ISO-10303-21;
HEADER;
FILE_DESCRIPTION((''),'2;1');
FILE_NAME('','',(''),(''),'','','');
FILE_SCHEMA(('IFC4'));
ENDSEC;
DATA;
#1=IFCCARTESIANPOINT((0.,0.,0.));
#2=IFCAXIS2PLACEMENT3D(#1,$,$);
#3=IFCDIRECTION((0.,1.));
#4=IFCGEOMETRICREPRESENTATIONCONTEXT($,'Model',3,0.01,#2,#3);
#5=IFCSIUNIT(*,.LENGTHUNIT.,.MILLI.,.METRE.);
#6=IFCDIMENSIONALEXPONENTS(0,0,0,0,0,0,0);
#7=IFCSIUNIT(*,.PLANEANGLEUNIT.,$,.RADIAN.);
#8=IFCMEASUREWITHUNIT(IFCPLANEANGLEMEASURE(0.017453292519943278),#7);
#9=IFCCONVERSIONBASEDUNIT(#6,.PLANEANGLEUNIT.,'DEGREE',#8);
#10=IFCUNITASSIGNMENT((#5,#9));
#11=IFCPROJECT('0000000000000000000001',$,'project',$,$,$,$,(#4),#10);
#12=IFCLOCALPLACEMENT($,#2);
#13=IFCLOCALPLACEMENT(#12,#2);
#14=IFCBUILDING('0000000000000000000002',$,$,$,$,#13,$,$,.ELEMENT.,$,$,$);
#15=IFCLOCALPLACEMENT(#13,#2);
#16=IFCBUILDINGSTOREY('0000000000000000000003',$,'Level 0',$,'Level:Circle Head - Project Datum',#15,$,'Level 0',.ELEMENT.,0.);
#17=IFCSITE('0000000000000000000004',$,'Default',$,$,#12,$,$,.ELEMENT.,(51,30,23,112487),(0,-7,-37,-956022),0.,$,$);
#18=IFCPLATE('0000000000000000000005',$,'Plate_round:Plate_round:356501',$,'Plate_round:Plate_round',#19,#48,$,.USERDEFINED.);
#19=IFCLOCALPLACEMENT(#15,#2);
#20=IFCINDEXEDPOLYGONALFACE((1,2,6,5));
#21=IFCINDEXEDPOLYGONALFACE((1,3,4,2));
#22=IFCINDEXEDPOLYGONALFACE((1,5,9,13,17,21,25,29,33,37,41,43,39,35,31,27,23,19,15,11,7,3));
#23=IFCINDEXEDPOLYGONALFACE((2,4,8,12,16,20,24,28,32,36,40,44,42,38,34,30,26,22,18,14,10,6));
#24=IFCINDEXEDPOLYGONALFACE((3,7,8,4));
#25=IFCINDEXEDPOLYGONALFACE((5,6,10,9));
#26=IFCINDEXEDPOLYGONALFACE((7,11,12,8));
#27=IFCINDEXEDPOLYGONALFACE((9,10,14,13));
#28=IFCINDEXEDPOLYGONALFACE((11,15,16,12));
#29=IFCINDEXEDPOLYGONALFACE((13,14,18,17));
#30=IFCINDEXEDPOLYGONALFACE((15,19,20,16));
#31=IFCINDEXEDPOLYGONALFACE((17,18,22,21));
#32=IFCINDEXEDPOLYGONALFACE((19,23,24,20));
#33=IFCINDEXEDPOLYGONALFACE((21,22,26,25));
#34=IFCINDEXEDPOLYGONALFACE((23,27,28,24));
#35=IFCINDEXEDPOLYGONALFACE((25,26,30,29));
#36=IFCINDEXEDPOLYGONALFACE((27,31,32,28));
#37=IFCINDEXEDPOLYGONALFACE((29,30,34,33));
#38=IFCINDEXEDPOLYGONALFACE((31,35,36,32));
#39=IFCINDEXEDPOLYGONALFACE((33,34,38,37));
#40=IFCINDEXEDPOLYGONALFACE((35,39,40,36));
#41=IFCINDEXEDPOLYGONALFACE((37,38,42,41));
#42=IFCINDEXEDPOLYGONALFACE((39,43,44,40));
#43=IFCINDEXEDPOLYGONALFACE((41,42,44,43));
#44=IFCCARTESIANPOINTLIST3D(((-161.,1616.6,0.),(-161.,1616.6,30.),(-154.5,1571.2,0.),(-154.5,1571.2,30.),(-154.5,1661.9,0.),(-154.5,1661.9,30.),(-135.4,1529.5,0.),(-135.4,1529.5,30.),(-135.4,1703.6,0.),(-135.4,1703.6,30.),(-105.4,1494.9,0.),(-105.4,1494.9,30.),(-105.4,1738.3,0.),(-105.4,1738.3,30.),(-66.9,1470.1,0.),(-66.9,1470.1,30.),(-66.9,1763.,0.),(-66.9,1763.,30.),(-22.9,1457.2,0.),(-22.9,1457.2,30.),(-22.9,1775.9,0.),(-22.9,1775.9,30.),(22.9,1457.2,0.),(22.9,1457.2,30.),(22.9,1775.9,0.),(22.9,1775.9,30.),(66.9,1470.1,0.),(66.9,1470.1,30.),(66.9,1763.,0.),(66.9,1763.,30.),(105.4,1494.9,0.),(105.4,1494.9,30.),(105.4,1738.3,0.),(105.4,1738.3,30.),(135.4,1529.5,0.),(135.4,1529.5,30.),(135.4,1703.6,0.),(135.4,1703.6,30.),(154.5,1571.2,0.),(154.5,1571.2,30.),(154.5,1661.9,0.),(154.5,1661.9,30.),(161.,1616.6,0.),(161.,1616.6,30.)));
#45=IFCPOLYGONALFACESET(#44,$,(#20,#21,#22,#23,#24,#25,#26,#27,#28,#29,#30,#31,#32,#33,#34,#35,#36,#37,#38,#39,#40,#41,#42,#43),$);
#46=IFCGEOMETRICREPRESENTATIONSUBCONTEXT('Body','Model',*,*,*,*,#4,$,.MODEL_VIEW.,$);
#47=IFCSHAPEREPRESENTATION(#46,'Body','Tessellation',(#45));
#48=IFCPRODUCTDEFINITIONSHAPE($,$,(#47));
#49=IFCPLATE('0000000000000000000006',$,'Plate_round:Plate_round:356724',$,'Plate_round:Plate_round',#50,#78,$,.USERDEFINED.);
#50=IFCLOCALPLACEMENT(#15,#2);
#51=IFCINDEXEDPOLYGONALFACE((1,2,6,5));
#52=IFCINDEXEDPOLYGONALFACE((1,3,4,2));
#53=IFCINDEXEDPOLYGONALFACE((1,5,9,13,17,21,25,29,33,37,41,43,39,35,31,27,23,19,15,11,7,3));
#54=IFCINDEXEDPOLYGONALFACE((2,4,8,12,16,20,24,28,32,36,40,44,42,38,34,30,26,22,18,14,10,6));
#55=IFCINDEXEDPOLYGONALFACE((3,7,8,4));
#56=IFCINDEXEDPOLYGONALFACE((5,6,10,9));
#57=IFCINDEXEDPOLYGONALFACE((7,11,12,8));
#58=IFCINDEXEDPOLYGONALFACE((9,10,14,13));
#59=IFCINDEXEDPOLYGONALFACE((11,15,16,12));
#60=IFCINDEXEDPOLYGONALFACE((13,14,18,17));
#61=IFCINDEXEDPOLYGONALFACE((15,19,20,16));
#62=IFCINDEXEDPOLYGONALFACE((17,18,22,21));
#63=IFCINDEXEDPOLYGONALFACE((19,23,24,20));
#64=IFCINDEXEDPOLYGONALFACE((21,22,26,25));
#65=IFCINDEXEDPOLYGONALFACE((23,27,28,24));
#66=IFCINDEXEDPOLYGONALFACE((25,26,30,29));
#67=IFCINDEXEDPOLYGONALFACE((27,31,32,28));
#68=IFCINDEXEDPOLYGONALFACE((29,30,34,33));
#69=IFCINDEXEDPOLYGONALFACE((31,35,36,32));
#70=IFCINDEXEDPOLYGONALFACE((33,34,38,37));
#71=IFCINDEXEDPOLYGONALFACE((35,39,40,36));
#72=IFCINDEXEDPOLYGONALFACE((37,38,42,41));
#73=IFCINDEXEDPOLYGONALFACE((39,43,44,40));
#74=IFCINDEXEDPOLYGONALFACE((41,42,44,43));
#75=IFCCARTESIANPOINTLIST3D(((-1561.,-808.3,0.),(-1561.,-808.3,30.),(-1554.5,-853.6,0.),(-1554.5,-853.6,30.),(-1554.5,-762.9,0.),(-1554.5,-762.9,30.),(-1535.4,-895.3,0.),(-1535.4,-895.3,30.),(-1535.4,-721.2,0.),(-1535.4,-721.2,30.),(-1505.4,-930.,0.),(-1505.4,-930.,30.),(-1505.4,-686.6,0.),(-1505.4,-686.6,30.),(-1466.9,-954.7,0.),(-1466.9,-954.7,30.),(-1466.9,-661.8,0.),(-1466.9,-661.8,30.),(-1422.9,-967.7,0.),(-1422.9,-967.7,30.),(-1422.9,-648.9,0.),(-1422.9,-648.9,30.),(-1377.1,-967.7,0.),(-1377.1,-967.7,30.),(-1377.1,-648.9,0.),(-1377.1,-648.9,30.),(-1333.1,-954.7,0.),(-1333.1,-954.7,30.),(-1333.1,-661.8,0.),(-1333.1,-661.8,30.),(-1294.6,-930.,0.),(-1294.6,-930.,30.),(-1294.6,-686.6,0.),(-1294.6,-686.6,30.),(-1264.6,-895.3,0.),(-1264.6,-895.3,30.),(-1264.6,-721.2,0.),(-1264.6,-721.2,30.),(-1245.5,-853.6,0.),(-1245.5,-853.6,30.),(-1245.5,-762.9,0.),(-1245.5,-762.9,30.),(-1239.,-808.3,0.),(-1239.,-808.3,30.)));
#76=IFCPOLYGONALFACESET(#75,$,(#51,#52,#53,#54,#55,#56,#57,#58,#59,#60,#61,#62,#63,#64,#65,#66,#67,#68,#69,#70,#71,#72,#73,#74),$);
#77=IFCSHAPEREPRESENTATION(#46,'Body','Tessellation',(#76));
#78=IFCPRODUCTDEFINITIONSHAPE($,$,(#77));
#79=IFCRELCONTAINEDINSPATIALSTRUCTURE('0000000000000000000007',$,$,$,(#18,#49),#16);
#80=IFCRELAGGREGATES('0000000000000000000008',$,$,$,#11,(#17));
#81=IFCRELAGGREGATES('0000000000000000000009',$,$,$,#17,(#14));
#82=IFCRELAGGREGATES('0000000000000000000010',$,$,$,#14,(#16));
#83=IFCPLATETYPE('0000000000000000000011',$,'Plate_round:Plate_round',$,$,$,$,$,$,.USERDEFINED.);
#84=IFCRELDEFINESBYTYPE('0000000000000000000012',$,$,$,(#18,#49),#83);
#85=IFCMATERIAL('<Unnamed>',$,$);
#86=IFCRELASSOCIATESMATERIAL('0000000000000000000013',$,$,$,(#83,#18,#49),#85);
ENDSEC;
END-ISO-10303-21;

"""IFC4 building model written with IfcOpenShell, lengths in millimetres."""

from ifc_helpers import new_model, entity, si_unit, converted_unit, direction, frame, origin, place, context, subcontext, project, spatial, arc, indexed_curve, outline, extrude, source, transform, mapped, material, type_object, type_shapes, element, save


model = new_model("IFC4")

# Units and contexts
model_context = context("Model", 3, precision=0.01, world=origin(), true_north=direction((0.0, 1.0)))
body_context = subcontext(model_context, "Body", "Model", "MODEL_VIEW")
ifc_project = project(units=[si_unit("LENGTHUNIT", "METRE", prefix="MILLI"), converted_unit("PLANEANGLEUNIT", "DEGREE", entity("IfcPlaneAngleMeasure", 0.017453292519943278), si_unit("PLANEANGLEUNIT", "RADIAN"), dimensions=[0, 0, 0, 0, 0, 0, 0])], contexts=[model_context])

# Site, building, storey
site_placement = place(None, origin())
site = spatial("IfcSite", under=ifc_project, at=site_placement, Name="Default", CompositionType="ELEMENT", RefLatitude=(51, 30, 23, 112487), RefLongitude=(0, -7, -37, -956022), RefElevation=0.0)
building_placement = place(site_placement, origin())
building = spatial("IfcBuilding", under=site, at=building_placement, CompositionType="ELEMENT")
storey_placement = place(building_placement, origin())
storey = spatial("IfcBuildingStorey", under=building, at=storey_placement, Name="Level 0", ObjectType="Level:Circle Head - Project Datum", LongName="Level 0", CompositionType="ELEMENT", Elevation=0.0)

# Plates
ifc_material_1 = material(Name="<Unnamed>")
plate_type = type_object("IfcPlateType", Name="Plate_round:Plate_round", PredefinedType="USERDEFINED", material=ifc_material_1)
shared_shape_1 = source(origin(), body_context, "Body", "SweptSolid", [
    extrude(outline(indexed_curve([(-161.0, 0.0), (0.0, -161.0), (161.0, 0.0), (0.0, 161.0)], segments=[arc(1, 2, 3), arc(3, 4, 1)], self_intersect=False)), origin(), (0.0, 0.0, 1.0), 30.0),
])
type_shapes(plate_type, [shared_shape_1])
for number, where, name in (
    (1, (0.0, 1616.6, 0.0), "Plate_round:Plate_round:356501"),
    (2, (-1400.0, -808.3, 0.0), "Plate_round:Plate_round:356724"),
):
    element("IfcPlate", number, at=place(storey_placement, frame(where)), inside=storey, type_object=plate_type, material=ifc_material_1, Name=name, ObjectType="Plate_round:Plate_round", PredefinedType="USERDEFINED", context=body_context, shape_type="MappedRepresentation", body=[
        mapped(shared_shape_1, transform((0.0, 0.0, 0.0), scale=1.0)),
    ])

save(model, "model.ifc")
